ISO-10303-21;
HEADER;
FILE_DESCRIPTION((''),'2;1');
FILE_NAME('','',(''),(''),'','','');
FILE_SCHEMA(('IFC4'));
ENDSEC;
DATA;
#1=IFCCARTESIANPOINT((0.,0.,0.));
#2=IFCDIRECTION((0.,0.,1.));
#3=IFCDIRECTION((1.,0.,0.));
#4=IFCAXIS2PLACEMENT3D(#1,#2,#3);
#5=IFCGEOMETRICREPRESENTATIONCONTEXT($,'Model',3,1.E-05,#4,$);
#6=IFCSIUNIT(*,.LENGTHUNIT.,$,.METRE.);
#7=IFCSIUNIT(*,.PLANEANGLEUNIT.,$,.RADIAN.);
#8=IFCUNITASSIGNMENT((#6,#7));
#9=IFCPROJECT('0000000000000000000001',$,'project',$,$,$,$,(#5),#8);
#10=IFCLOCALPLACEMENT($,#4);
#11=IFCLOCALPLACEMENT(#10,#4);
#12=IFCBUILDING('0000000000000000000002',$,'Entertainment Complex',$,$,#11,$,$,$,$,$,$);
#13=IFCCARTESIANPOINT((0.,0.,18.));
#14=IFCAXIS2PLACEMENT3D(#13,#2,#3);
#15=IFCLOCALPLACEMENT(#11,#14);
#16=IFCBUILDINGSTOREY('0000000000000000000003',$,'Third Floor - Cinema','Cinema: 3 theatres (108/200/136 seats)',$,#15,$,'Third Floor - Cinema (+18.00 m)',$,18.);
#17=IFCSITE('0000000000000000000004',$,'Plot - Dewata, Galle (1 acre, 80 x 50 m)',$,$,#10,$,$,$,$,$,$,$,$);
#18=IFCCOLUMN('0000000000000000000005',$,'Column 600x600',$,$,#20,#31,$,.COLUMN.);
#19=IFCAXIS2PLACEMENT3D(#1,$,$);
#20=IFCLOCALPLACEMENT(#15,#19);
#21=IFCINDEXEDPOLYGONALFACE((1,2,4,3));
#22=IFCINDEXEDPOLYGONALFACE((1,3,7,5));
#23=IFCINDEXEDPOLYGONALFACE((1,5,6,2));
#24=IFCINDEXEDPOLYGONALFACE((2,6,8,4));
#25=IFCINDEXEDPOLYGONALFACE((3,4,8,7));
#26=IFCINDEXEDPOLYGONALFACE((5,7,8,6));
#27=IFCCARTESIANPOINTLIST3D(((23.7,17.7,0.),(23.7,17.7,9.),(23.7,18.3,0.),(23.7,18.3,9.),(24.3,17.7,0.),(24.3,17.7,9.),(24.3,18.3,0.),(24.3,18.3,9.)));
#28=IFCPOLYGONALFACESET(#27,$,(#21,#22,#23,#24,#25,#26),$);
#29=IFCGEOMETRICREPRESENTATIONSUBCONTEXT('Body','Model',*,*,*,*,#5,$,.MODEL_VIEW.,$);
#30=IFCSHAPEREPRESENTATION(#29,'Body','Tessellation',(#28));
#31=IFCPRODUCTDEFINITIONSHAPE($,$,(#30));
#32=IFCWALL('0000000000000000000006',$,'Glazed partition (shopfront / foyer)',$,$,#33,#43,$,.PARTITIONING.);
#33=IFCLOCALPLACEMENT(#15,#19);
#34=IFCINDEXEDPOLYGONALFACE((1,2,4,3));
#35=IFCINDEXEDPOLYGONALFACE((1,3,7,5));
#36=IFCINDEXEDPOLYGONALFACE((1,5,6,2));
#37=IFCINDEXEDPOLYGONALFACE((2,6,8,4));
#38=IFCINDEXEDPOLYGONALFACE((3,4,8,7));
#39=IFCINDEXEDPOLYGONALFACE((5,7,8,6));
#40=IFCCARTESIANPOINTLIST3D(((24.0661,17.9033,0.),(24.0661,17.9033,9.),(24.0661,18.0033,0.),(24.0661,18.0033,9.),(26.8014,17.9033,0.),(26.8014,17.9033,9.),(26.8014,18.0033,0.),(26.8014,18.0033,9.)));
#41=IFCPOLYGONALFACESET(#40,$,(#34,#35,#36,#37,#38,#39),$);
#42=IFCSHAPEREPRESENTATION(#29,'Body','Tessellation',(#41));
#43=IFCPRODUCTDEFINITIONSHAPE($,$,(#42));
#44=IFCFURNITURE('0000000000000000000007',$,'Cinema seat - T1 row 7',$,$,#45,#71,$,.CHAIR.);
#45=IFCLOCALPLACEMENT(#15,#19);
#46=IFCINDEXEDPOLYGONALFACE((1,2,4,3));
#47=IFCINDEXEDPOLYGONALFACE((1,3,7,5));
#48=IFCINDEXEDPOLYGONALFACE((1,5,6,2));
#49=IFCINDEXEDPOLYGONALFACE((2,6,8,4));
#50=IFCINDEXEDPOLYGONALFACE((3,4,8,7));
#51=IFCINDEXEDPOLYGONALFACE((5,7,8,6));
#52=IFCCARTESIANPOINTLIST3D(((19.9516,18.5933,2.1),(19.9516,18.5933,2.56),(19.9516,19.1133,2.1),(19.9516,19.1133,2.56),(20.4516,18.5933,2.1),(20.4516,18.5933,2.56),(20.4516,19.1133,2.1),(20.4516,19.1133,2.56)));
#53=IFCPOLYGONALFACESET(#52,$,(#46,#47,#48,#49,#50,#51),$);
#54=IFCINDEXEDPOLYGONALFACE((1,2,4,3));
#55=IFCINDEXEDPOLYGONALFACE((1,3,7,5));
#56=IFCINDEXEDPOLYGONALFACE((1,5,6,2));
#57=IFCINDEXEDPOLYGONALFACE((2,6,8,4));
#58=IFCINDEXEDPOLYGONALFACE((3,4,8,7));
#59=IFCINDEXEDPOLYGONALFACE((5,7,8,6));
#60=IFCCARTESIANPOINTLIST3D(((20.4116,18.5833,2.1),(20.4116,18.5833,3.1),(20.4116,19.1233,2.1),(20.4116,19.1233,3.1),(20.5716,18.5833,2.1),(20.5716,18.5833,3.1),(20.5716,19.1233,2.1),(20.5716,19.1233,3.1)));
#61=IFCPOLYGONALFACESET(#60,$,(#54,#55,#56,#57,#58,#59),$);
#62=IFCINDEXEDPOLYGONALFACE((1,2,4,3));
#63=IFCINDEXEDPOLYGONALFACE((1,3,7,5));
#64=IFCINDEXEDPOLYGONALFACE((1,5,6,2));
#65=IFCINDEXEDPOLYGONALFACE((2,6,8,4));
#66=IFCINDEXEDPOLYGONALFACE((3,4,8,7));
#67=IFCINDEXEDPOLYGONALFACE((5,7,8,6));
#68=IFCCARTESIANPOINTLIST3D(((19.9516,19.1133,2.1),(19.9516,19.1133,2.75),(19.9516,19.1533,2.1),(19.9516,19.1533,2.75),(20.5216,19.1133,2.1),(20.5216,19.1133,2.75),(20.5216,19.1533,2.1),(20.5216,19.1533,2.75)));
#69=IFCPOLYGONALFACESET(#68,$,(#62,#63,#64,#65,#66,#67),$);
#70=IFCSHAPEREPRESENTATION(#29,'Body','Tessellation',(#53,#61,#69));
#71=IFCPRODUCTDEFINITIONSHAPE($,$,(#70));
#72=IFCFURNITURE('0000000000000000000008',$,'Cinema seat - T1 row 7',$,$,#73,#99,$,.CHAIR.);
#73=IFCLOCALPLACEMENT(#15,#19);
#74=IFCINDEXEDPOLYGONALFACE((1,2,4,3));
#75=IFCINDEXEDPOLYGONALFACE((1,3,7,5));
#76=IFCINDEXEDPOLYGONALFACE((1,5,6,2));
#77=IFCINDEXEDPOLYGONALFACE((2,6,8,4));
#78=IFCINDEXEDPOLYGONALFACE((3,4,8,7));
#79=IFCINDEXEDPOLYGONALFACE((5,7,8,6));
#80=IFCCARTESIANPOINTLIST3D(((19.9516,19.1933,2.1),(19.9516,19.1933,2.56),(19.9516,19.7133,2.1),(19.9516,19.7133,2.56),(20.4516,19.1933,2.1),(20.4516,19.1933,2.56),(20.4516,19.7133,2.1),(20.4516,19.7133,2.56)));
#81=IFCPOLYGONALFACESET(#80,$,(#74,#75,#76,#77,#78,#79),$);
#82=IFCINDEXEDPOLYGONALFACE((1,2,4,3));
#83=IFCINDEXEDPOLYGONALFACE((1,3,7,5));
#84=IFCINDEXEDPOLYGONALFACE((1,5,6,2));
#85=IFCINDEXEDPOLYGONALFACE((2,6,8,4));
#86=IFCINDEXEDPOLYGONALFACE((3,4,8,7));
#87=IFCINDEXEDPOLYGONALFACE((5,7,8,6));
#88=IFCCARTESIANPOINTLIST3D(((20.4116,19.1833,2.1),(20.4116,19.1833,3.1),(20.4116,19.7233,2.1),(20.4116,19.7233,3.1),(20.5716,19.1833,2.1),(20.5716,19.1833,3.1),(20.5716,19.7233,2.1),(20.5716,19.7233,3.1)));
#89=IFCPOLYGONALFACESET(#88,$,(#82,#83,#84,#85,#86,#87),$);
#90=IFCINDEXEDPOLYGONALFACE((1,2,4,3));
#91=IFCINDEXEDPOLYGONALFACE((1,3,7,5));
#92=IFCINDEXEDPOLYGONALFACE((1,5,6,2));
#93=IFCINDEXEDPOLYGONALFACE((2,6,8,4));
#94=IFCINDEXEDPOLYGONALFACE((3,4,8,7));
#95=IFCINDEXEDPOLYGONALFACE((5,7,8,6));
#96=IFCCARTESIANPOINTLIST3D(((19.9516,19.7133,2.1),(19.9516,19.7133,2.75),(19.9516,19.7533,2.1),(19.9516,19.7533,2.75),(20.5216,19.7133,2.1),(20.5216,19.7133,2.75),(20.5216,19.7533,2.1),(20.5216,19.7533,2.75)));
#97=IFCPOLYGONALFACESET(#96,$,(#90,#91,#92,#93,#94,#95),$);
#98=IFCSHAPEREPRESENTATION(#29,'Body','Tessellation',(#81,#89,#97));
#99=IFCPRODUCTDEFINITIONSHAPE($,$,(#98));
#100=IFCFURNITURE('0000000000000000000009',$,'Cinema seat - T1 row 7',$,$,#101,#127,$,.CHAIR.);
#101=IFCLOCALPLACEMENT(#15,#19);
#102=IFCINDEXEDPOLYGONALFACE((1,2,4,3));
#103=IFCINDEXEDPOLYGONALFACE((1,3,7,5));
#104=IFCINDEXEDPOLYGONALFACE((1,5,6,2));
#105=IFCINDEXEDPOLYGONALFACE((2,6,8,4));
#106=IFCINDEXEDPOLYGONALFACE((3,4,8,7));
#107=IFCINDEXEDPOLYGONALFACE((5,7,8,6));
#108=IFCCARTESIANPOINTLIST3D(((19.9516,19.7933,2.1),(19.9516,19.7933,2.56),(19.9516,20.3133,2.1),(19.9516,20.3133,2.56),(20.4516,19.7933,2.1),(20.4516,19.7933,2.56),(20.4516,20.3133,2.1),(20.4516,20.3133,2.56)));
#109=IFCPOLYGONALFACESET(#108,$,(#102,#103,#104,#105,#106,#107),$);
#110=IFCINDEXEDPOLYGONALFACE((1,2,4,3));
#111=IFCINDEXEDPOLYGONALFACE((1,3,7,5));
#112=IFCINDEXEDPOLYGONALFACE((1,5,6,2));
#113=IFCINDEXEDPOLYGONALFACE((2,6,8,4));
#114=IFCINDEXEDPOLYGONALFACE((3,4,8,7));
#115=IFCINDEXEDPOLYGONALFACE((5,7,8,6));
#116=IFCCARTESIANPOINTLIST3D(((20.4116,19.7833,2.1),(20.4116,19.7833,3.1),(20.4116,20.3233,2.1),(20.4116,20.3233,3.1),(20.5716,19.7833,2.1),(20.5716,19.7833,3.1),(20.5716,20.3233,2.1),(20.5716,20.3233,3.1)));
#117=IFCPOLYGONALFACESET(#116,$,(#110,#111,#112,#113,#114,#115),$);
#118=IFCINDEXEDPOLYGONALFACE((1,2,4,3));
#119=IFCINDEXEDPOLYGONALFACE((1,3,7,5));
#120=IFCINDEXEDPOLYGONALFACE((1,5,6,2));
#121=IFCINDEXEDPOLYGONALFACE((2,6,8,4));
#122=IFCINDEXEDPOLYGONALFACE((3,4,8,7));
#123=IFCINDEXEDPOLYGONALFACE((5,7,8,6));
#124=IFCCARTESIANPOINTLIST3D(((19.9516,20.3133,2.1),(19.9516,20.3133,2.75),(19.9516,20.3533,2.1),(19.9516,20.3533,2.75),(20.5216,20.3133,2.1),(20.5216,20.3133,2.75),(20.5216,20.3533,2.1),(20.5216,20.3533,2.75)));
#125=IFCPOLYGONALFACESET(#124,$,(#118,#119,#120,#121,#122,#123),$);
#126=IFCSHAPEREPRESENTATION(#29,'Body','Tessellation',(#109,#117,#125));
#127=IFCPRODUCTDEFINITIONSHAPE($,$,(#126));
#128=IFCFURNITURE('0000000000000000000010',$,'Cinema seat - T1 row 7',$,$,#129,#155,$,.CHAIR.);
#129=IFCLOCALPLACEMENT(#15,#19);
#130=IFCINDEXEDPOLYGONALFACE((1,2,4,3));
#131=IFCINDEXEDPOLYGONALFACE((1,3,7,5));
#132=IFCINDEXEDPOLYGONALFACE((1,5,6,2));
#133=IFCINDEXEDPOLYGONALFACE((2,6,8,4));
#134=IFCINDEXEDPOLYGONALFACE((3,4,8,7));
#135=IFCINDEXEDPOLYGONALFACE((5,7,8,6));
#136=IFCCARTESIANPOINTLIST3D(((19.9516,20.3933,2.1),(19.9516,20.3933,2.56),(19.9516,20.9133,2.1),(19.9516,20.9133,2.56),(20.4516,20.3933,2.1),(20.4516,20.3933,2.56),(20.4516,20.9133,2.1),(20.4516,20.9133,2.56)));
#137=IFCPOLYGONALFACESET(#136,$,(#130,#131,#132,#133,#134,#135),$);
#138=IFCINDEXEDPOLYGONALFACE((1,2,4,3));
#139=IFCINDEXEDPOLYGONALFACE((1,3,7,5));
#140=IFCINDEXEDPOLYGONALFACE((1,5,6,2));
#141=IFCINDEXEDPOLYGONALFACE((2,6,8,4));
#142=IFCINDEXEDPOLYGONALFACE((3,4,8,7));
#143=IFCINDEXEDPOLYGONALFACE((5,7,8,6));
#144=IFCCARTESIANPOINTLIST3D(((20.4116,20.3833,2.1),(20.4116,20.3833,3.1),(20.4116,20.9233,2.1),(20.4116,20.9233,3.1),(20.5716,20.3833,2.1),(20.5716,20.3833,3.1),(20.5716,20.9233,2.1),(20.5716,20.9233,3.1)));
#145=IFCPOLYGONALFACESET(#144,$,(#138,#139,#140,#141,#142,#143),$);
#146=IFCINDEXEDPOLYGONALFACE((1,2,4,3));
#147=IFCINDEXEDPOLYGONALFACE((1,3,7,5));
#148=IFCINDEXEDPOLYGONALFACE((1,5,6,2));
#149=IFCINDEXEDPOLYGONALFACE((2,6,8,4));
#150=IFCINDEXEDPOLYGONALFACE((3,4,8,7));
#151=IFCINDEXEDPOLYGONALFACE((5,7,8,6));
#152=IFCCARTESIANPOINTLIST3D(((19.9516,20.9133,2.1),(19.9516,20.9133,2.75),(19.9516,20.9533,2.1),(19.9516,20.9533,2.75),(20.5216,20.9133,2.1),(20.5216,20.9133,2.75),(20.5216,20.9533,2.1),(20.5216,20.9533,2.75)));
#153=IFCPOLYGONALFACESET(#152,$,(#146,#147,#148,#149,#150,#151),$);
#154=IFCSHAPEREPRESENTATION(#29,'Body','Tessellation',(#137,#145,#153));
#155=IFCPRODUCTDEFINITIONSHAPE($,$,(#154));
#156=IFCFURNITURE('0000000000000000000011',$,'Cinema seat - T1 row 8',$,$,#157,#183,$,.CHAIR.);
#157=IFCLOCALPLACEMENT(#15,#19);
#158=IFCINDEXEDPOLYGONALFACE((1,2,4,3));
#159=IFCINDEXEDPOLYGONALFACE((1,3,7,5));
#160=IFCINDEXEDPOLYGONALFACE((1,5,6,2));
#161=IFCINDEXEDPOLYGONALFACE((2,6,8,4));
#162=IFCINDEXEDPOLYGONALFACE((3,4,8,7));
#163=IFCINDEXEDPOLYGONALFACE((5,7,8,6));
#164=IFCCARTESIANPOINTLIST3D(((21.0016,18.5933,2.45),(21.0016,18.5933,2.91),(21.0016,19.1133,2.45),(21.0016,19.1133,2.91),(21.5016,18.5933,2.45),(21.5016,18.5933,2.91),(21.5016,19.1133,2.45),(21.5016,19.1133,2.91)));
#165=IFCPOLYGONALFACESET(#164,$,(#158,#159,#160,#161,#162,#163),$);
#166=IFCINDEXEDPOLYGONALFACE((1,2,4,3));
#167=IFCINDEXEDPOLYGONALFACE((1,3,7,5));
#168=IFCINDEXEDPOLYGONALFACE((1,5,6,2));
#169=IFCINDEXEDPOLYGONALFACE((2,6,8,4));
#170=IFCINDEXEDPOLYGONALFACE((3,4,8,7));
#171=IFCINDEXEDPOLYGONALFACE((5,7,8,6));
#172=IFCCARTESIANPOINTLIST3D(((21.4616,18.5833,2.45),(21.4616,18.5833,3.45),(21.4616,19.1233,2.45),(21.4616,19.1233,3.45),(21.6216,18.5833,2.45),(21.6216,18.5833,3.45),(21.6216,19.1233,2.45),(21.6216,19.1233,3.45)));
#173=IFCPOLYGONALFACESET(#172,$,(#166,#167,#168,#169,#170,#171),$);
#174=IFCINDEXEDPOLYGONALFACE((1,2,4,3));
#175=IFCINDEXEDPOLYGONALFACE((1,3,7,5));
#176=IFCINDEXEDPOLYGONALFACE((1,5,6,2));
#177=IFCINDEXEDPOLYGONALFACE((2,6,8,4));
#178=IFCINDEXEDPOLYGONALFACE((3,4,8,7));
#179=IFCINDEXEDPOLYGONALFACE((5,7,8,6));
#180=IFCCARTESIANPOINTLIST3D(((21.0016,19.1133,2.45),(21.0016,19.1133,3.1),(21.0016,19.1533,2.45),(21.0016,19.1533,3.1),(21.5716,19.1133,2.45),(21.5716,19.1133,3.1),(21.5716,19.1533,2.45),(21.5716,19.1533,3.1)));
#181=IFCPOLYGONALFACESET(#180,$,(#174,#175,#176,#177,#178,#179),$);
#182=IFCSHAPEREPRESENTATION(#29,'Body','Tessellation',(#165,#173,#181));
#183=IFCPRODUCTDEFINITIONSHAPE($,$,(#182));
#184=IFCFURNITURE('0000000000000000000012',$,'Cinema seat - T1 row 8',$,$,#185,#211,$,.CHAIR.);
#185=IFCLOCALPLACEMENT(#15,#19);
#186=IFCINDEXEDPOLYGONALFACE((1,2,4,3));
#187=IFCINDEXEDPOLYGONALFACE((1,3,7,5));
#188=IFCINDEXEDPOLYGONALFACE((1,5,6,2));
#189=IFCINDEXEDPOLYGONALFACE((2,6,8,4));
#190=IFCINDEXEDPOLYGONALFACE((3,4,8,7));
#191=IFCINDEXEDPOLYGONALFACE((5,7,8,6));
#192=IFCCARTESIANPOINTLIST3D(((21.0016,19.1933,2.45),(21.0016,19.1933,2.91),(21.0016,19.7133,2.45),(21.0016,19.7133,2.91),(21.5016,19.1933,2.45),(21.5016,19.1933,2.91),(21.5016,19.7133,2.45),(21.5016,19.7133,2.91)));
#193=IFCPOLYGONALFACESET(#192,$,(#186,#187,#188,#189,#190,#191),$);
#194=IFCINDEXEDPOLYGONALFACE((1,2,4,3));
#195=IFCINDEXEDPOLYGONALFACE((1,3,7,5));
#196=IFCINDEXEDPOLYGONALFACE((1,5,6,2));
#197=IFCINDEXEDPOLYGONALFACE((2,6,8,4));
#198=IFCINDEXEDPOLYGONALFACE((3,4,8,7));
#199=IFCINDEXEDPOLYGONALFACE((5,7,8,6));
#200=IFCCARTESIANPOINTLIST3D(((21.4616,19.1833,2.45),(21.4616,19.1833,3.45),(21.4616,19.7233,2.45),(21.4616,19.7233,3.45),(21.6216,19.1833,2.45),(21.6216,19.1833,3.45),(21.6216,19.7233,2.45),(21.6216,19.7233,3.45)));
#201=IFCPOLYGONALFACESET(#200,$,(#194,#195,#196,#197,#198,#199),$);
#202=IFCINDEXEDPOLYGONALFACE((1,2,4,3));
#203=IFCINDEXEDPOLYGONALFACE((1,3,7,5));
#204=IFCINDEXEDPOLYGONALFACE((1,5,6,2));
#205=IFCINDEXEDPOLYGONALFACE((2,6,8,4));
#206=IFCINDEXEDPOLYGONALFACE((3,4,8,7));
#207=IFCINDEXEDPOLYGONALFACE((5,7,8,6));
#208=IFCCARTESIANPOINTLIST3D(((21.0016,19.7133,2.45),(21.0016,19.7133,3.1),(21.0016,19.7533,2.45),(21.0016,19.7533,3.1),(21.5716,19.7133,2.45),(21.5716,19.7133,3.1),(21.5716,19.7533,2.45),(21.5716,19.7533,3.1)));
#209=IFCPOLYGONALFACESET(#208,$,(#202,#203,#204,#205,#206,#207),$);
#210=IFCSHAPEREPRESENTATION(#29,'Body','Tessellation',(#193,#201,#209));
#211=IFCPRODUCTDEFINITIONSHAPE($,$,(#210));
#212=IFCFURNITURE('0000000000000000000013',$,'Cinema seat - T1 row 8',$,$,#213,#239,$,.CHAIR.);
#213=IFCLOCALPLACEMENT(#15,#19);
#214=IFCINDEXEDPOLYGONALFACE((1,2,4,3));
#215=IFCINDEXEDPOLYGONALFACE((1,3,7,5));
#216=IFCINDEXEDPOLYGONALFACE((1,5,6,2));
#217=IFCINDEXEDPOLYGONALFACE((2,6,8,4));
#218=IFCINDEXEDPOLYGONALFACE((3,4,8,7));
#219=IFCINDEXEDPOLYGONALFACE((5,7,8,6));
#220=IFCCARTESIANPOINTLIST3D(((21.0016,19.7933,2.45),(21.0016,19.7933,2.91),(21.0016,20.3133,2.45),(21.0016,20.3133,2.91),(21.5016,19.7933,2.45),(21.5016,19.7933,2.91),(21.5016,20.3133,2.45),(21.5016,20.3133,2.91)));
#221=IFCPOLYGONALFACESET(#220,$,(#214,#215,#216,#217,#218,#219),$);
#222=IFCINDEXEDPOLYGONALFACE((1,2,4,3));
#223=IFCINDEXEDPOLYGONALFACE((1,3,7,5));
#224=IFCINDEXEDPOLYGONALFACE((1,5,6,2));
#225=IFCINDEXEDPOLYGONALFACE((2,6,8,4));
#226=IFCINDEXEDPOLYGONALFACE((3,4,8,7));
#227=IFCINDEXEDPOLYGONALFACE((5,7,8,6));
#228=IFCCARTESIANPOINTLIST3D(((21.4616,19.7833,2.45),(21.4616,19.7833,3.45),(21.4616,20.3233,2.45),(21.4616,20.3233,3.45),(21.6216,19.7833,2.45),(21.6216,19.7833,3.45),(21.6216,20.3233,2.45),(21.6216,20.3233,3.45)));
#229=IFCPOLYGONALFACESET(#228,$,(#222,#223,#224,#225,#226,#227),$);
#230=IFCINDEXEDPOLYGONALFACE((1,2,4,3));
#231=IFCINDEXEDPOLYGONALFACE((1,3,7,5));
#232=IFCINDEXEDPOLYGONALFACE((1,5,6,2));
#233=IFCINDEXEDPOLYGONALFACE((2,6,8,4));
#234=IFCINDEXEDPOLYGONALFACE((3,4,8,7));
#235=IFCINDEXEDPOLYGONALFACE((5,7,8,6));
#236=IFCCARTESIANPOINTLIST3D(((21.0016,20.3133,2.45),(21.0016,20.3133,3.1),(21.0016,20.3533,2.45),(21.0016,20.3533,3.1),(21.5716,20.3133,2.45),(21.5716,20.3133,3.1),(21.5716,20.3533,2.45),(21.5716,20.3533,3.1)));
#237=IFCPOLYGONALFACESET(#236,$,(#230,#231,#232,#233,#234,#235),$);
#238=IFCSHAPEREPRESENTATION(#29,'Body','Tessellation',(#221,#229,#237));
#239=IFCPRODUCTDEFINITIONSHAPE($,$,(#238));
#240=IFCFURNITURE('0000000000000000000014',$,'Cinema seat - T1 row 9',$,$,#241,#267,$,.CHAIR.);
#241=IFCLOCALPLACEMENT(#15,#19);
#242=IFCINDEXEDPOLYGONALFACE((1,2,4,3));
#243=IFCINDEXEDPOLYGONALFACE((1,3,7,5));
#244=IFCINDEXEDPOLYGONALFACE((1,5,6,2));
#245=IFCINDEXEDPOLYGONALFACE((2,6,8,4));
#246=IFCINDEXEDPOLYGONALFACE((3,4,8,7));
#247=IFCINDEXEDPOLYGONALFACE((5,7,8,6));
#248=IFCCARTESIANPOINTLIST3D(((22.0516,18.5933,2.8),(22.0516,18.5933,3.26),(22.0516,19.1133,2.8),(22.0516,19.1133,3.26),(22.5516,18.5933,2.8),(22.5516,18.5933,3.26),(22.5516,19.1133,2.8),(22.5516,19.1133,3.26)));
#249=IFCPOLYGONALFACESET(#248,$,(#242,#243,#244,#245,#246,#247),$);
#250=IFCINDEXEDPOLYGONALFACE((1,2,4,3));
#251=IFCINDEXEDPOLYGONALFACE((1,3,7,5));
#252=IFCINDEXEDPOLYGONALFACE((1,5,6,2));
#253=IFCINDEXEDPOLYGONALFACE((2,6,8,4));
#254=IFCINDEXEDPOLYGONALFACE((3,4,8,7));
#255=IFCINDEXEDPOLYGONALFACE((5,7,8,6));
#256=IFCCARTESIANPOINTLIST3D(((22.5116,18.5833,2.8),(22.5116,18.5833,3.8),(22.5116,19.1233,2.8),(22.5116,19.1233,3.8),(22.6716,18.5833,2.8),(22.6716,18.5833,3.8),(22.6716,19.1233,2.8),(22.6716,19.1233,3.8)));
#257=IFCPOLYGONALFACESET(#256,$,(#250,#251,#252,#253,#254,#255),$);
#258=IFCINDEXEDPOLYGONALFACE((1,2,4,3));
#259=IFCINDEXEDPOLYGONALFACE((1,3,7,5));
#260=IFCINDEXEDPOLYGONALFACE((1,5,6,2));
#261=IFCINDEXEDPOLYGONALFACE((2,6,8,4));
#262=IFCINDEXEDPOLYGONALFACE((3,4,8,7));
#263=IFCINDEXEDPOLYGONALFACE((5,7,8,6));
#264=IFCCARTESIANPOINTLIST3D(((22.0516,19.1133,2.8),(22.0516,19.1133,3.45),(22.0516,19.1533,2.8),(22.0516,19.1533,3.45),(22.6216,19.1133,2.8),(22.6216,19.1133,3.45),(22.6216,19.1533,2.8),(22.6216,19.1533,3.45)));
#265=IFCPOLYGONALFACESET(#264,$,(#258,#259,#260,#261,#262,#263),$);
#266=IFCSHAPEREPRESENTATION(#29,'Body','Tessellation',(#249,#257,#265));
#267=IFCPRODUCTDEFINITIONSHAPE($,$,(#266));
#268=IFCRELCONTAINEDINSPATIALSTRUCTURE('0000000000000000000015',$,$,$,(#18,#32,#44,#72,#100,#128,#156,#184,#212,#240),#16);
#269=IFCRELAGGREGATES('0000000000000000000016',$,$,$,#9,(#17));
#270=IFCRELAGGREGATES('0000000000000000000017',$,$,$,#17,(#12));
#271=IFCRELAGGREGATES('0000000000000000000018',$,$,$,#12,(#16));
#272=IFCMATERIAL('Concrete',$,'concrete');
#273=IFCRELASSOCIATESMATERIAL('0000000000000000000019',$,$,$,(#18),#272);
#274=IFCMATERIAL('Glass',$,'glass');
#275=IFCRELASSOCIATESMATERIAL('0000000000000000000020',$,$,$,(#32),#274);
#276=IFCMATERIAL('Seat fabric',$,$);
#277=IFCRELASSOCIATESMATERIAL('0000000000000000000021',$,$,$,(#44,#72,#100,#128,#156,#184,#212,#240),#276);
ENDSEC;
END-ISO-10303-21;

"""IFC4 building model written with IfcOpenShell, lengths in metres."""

from ifc_helpers import new_model, si_unit, frame, origin_with_axes, place, context, subcontext, project, spatial, polyline, outline, extrude, material, element, save


model = new_model("IFC4")

# Units and contexts
model_context = context("Model", 3, precision=1e-05, world=origin_with_axes())
body_context = subcontext(model_context, "Body", "Model", "MODEL_VIEW")
ifc_project = project(units=[si_unit("LENGTHUNIT", "METRE"), si_unit("PLANEANGLEUNIT", "RADIAN")], contexts=[model_context])

# Site, building, storey
site_placement = place(None, origin_with_axes())
site = spatial("IfcSite", under=ifc_project, at=site_placement, Name="Plot - Dewata, Galle (1 acre, 80 x 50 m)")
building_placement = place(site_placement, origin_with_axes())
building = spatial("IfcBuilding", under=site, at=building_placement, Name="Entertainment Complex")
storey_placement = place(building_placement, frame((0.0, 0.0, 18.0), z_axis=(0.0, 0.0, 1.0), x_axis=(1.0, 0.0, 0.0)))
storey = spatial("IfcBuildingStorey", under=building, at=storey_placement, Name="Third Floor - Cinema", Description="Cinema: 3 theatres (108/200/136 seats)", LongName="Third Floor - Cinema (+18.00 m)", Elevation=18.0)

# Column
ifc_material_1 = material(Name="Concrete", Category="concrete")
column_placement = place(storey_placement, frame((24.0, 18.0, 0.0), z_axis=(0.0, 0.0, 1.0), x_axis=(1.0, 0.0, 0.0)))
element("IfcColumn", 1, at=column_placement, inside=storey, material=ifc_material_1, Name="Column 600x600", PredefinedType="COLUMN", context=body_context, shape_type="SweptSolid", body=[
    extrude(outline(polyline([(-0.3, -0.3), (0.3, -0.3), (0.3, 0.3), (-0.3, 0.3), (-0.3, -0.3)])), origin_with_axes(), (0.0, 0.0, 1.0), 9.0),
])

# Wall
ifc_material_2 = material(Name="Glass", Category="glass")
wall_placement = place(storey_placement, frame((24.0661, 17.9533, 0.0), z_axis=(0.0, 0.0, 1.0), x_axis=(1.0, 0.0, 0.0)))
element("IfcWall", 2, at=wall_placement, inside=storey, material=ifc_material_2, Name="Glazed partition (shopfront / foyer)", PredefinedType="PARTITIONING", context=body_context, shape_type="SweptSolid", body=[
    extrude(outline(polyline([(0.0, -0.05), (2.7353, -0.05), (2.7353, 0.05), (0.0, 0.05), (0.0, -0.05)])), origin_with_axes(), (0.0, 0.0, 1.0), 9.0),
])

# Furniture
ifc_material_3 = material(Name="Seat fabric")
for number, where, z_axis, x_axis, name in (
    (3, (20.5716, 18.8533, 2.1), (0.0, 0.0, 1.0), (1.0, 0.0, 0.0), "Cinema seat - T1 row 7"),
    (4, (20.5716, 19.4533, 2.1), (0.0, 0.0, 1.0), (1.0, 0.0, 0.0), "Cinema seat - T1 row 7"),
    (5, (20.5716, 20.0533, 2.1), (0.0, 0.0, 1.0), (1.0, 0.0, 0.0), "Cinema seat - T1 row 7"),
    (6, (20.5716, 20.6533, 2.1), (0.0, 0.0, 1.0), (1.0, 0.0, 0.0), "Cinema seat - T1 row 7"),
    (7, (21.6216, 18.8533, 2.45), (0.0, 0.0, 1.0), (1.0, 0.0, 0.0), "Cinema seat - T1 row 8"),
    (8, (21.6216, 19.4533, 2.45), (0.0, 0.0, 1.0), (1.0, 0.0, 0.0), "Cinema seat - T1 row 8"),
    (9, (21.6216, 20.0533, 2.45), (0.0, 0.0, 1.0), (1.0, 0.0, 0.0), "Cinema seat - T1 row 8"),
    (10, (22.6716, 18.8533, 2.8), (0.0, 0.0, 1.0), (1.0, 0.0, 0.0), "Cinema seat - T1 row 9"),
):
    element("IfcFurniture", number, at=place(storey_placement, frame(where, z_axis=z_axis, x_axis=x_axis)), inside=storey, material=ifc_material_3, Name=name, PredefinedType="CHAIR", context=body_context, shape_type="SweptSolid", body=[
        extrude(outline(polyline([(-0.62, -0.26), (-0.12, -0.26), (-0.12, 0.26), (-0.62, 0.26), (-0.62, -0.26)])), origin_with_axes(), (0.0, 0.0, 1.0), 0.46),
        extrude(outline(polyline([(-0.16, -0.27), (0.0, -0.27), (0.0, 0.27), (-0.16, 0.27), (-0.16, -0.27)])), origin_with_axes(), (0.0, 0.0, 1.0), 1.0),
        extrude(outline(polyline([(-0.62, 0.26), (-0.05, 0.26), (-0.05, 0.3), (-0.62, 0.3), (-0.62, 0.26)])), origin_with_axes(), (0.0, 0.0, 1.0), 0.65),
    ])

save(model, "model.ifc")
